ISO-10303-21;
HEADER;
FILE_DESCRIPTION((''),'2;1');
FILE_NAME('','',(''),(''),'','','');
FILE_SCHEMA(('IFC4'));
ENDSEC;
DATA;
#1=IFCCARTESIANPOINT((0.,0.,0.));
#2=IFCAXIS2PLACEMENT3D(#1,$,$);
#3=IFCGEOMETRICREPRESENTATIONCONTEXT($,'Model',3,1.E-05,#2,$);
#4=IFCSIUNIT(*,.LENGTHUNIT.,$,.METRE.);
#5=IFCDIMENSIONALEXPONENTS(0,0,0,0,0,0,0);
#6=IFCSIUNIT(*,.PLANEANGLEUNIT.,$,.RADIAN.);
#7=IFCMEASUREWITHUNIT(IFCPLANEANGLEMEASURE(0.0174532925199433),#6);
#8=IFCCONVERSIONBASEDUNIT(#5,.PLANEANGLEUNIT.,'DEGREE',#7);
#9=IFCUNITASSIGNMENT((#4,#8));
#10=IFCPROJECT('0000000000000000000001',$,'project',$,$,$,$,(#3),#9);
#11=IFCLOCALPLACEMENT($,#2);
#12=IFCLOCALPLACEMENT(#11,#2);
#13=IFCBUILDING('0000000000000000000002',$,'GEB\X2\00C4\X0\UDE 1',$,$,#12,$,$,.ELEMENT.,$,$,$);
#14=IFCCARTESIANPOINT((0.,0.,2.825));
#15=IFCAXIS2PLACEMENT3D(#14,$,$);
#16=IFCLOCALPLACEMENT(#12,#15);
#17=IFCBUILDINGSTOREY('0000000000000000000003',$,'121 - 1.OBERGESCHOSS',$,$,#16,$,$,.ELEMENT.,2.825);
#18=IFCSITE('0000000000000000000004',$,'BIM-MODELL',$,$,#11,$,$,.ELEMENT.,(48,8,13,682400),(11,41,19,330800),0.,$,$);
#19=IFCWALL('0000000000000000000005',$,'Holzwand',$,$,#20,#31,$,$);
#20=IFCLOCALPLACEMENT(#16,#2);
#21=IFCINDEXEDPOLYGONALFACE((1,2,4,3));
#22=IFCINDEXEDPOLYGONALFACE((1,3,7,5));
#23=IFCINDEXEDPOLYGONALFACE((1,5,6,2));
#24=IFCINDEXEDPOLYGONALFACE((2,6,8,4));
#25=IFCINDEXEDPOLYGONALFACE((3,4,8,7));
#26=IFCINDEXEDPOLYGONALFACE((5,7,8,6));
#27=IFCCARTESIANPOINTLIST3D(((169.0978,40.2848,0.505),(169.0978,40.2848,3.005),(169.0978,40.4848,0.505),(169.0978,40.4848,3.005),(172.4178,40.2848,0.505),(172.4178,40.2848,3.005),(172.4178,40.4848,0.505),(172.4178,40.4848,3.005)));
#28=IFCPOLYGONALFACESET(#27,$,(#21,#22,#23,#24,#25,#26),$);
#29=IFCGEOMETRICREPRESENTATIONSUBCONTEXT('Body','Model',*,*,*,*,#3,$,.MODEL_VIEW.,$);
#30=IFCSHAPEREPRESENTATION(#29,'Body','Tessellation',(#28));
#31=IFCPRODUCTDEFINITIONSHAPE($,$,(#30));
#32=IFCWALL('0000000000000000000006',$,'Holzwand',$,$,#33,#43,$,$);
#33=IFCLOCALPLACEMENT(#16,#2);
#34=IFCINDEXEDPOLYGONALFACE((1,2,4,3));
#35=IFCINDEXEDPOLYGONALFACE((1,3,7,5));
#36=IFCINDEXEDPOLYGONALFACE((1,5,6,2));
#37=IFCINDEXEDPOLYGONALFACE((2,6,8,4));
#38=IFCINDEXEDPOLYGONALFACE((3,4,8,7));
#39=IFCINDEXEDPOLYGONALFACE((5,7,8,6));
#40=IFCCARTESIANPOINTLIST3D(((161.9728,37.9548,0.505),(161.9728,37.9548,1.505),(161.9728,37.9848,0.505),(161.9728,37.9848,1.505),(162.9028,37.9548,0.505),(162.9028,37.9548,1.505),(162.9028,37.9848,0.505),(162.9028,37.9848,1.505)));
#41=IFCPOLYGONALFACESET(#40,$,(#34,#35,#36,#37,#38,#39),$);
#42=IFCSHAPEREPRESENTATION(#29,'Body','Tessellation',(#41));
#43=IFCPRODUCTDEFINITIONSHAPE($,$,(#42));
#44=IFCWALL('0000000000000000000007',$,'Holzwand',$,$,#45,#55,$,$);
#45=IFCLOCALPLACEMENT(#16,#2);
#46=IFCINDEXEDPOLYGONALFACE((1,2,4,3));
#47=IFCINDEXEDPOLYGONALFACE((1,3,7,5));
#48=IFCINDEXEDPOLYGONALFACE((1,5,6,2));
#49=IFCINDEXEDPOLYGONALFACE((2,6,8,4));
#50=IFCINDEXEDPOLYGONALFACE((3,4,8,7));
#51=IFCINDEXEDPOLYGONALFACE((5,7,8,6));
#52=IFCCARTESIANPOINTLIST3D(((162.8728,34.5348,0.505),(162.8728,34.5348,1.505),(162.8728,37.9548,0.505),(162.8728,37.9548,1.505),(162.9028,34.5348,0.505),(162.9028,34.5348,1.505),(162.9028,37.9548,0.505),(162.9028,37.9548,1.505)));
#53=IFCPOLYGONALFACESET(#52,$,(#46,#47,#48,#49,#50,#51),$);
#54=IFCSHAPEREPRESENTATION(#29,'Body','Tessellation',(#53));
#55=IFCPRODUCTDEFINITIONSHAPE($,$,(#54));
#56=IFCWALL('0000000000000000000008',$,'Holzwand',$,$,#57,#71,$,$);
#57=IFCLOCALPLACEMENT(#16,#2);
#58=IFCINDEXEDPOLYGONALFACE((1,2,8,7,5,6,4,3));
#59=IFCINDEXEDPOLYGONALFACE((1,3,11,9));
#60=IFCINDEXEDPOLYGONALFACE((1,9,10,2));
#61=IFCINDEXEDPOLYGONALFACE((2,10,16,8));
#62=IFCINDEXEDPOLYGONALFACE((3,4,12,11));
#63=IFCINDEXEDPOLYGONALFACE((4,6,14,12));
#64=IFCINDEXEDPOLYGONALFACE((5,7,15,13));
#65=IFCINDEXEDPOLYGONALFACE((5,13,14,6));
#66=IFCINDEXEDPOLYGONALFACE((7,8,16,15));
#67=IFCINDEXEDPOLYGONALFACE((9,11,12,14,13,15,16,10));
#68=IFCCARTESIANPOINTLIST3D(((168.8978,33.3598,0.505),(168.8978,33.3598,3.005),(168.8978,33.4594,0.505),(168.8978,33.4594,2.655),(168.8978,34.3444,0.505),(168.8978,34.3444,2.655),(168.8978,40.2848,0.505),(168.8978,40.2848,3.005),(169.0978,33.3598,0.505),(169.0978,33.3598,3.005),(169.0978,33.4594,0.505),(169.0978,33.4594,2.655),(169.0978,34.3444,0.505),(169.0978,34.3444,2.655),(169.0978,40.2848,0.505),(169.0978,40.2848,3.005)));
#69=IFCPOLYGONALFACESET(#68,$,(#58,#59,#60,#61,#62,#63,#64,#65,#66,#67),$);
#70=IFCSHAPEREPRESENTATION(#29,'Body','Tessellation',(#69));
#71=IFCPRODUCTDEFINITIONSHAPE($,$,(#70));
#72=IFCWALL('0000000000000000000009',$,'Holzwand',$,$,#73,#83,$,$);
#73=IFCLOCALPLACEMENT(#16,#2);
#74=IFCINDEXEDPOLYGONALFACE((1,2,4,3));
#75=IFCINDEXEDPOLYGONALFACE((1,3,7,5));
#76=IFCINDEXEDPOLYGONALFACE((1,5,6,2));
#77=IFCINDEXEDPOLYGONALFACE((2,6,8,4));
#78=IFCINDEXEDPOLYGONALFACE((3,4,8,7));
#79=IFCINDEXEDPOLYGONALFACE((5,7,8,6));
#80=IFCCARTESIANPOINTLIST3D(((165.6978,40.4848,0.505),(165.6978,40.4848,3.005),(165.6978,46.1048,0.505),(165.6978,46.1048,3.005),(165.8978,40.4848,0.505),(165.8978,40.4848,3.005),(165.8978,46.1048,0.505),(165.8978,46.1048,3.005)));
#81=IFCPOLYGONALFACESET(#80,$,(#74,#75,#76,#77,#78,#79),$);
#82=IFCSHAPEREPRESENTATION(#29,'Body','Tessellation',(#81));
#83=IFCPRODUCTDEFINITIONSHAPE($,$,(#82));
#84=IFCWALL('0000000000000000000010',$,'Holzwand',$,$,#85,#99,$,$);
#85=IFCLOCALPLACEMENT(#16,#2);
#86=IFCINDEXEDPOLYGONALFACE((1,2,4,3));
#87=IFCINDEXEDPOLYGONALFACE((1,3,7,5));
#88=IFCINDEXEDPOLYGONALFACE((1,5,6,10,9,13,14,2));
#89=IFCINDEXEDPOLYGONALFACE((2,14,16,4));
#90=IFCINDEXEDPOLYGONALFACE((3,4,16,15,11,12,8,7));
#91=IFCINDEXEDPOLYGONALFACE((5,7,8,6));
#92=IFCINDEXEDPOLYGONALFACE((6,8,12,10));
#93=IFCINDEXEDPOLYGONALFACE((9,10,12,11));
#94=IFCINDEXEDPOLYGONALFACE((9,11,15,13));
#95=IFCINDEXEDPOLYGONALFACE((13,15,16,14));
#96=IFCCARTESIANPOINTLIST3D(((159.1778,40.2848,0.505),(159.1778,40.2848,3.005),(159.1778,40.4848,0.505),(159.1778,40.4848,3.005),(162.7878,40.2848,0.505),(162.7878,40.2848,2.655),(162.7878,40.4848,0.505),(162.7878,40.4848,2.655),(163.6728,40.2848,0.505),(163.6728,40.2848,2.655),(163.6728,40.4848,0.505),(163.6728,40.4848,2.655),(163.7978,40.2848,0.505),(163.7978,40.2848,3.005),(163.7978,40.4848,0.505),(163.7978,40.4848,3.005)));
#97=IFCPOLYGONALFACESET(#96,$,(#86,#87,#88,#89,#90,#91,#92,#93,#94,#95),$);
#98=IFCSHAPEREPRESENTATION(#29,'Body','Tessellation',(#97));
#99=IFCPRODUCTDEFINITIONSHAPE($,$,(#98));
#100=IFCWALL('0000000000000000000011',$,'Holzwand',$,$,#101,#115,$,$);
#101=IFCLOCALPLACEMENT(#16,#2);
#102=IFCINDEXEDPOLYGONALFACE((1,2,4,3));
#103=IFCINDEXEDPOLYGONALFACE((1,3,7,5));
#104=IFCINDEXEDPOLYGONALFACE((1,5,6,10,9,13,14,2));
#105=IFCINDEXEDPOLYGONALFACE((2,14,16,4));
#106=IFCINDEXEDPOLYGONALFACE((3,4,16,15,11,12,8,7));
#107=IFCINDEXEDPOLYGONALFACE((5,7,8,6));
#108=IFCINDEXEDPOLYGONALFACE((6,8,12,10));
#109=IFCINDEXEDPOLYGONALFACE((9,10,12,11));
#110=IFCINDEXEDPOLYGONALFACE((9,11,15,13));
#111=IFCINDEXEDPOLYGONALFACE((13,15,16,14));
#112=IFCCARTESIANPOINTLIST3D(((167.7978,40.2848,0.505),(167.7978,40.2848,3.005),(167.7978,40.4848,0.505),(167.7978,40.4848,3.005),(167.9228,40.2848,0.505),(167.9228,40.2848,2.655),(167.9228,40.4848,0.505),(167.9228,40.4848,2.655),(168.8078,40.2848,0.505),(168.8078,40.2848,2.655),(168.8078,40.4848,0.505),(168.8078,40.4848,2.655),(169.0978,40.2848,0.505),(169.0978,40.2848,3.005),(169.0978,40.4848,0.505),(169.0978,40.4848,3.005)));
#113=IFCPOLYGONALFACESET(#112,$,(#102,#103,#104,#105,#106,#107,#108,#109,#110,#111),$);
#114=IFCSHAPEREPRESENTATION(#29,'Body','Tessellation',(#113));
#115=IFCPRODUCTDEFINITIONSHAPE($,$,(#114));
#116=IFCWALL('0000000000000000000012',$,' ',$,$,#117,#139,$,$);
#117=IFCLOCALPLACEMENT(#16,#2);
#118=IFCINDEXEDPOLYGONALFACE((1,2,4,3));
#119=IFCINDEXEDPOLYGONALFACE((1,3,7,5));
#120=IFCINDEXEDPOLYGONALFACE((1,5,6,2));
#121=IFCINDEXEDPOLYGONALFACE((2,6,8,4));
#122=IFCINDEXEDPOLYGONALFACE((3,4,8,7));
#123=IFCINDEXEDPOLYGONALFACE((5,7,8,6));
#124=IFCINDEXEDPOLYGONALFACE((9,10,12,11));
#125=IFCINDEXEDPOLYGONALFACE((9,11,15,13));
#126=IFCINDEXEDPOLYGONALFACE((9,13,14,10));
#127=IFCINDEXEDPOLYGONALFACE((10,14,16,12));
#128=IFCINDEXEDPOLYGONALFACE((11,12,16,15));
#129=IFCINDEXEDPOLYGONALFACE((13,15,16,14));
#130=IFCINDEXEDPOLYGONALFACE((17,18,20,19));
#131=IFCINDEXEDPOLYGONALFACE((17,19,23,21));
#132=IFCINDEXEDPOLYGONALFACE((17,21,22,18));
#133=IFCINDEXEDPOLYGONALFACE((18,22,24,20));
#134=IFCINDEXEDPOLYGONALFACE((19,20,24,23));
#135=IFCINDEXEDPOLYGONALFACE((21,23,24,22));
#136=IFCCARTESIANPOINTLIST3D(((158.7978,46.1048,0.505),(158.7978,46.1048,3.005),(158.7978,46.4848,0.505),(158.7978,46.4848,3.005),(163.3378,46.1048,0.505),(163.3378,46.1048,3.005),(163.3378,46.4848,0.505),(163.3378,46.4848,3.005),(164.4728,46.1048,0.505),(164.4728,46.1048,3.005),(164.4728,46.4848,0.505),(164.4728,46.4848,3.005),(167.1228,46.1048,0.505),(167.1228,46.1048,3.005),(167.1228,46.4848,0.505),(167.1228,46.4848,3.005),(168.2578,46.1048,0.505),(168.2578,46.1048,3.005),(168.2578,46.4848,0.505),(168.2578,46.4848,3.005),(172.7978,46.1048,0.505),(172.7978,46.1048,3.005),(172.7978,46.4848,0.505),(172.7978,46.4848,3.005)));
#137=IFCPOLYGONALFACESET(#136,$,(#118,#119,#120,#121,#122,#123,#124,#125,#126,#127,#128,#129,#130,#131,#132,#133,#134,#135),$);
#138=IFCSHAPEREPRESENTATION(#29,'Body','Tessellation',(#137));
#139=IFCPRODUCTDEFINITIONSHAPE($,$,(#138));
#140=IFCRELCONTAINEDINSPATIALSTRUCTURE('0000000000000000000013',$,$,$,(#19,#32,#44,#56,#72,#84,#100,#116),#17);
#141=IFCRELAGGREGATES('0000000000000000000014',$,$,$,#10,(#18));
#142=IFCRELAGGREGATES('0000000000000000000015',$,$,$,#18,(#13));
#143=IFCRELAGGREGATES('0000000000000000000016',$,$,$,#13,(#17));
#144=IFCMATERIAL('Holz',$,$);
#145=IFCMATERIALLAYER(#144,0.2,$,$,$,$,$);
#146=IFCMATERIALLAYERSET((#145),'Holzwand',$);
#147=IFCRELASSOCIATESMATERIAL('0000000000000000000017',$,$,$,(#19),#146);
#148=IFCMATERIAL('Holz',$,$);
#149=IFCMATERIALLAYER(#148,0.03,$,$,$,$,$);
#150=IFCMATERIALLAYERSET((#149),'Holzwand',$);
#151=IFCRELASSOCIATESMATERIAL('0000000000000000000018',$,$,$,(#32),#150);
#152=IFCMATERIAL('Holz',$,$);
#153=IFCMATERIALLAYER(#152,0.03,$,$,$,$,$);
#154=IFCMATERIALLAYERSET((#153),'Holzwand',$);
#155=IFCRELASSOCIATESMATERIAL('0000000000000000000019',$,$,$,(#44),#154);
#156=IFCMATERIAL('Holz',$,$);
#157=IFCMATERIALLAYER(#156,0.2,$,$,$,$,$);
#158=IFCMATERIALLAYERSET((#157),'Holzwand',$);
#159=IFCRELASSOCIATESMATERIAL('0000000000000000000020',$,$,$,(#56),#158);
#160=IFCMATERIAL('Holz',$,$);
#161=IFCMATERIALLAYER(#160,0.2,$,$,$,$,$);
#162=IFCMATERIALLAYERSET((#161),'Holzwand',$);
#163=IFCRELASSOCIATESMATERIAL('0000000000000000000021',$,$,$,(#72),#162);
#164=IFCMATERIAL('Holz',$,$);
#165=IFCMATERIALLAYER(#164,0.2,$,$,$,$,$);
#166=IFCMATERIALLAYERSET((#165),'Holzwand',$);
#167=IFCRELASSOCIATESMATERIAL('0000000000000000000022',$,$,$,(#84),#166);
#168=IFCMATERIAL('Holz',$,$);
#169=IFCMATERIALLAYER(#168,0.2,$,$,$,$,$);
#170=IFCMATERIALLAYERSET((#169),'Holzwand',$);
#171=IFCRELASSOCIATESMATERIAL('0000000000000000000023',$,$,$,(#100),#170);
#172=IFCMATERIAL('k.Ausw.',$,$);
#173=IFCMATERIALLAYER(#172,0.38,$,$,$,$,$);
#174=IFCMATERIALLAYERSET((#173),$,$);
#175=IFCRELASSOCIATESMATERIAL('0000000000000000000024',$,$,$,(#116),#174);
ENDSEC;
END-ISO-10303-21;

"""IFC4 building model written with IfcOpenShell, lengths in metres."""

from ifc_helpers import new_model, entity, si_unit, converted_unit, frame, frame_2d, origin, origin_with_axes, place, context, subcontext, project, spatial, polyline, rectangle, outline, extrude, material, layer, layer_set, layer_usage, element, save


model = new_model("IFC4")

# Units and contexts
model_context = context("Model", 3, precision=1e-05, world=origin())
body_context = subcontext(model_context, "Body", "Model", "MODEL_VIEW")
ifc_project = project(units=[si_unit("LENGTHUNIT", "METRE"), converted_unit("PLANEANGLEUNIT", "DEGREE", entity("IfcPlaneAngleMeasure", 0.0174532925199433), si_unit("PLANEANGLEUNIT", "RADIAN"), dimensions=[0, 0, 0, 0, 0, 0, 0])], contexts=[model_context])

# Site, building, storey
site_placement = place(None, origin())
site = spatial("IfcSite", under=ifc_project, at=site_placement, Name="BIM-MODELL", CompositionType="ELEMENT", RefLatitude=(48, 8, 13, 682400), RefLongitude=(11, 41, 19, 330800), RefElevation=0.0)
building_placement = place(site_placement, origin())
building = spatial("IfcBuilding", under=site, at=building_placement, Name="GEBÄUDE 1", CompositionType="ELEMENT")
storey_placement = place(building_placement, frame((0.0, 0.0, 2.825)))
storey = spatial("IfcBuildingStorey", under=building, at=storey_placement, Name="121 - 1.OBERGESCHOSS", CompositionType="ELEMENT", Elevation=2.825)

# Walls
ifc_material_1 = material(Name="Holz")
ifc_layer_1 = layer(ifc_material_1, 0.2)
ifc_layer_set_1 = layer_set([ifc_layer_1], Name="Holzwand")
ifc_layer_usage_1 = layer_usage(ifc_layer_set_1, "AXIS2", "POSITIVE", -0.1)
wall_1_placement = place(storey_placement, frame((172.4178, 40.4848, 0.505), z_axis=(0.0, 0.0, 1.0), x_axis=(-1.0, 0.0, 0.0)))
element("IfcWall", 1, at=wall_1_placement, inside=storey, material=ifc_layer_usage_1, Name="Holzwand", context=body_context, shape_type="SweptSolid", body=[
    extrude(rectangle(XDim=3.32, YDim=0.2, at=frame_2d((1.66, 0.1), x_axis=(1.0, 0.0))), origin_with_axes(), (0.0, 0.0, 1.0), 2.5),
])
ifc_material_2 = material(Name="Holz")
ifc_layer_2 = layer(ifc_material_2, 0.03)
ifc_layer_set_2 = layer_set([ifc_layer_2], Name="Holzwand")
ifc_layer_usage_2 = layer_usage(ifc_layer_set_2, "AXIS2", "POSITIVE", 0.0)
wall_2_placement = place(storey_placement, frame((161.9728, 37.9548, 0.505), z_axis=(0.0, 0.0, 1.0), x_axis=(1.0, 0.0, 0.0)))
element("IfcWall", 2, at=wall_2_placement, inside=storey, material=ifc_layer_usage_2, Name="Holzwand", context=body_context, shape_type="SweptSolid", body=[
    extrude(rectangle(XDim=0.93, YDim=0.03, at=frame_2d((0.465, 0.015), x_axis=(1.0, 0.0))), origin_with_axes(), (0.0, 0.0, 1.0), 1.0),
])
ifc_material_3 = material(Name="Holz")
ifc_layer_3 = layer(ifc_material_3, 0.03)
ifc_layer_set_3 = layer_set([ifc_layer_3], Name="Holzwand")
ifc_layer_usage_3 = layer_usage(ifc_layer_set_3, "AXIS2", "POSITIVE", 0.0)
wall_3_placement = place(storey_placement, frame((162.8728, 37.9548, 0.505), z_axis=(0.0, 0.0, 1.0), x_axis=(0.0, -1.0, 0.0)))
element("IfcWall", 3, at=wall_3_placement, inside=storey, material=ifc_layer_usage_3, Name="Holzwand", context=body_context, shape_type="SweptSolid", body=[
    extrude(rectangle(XDim=3.42, YDim=0.03, at=frame_2d((1.71, 0.015), x_axis=(1.0, 0.0))), origin_with_axes(), (0.0, 0.0, 1.0), 1.0),
])

# Wall, opening
ifc_material_4 = material(Name="Holz")
ifc_layer_4 = layer(ifc_material_4, 0.2)
ifc_layer_set_4 = layer_set([ifc_layer_4], Name="Holzwand")
ifc_layer_usage_4 = layer_usage(ifc_layer_set_4, "AXIS2", "POSITIVE", 0.0)
wall_4_placement = place(storey_placement, frame((168.8978, 40.2848, 0.505), z_axis=(0.0, 0.0, 1.0), x_axis=(0.0, -1.0, 0.0)))
wall_4 = element("IfcWall", 4, at=wall_4_placement, inside=storey, material=ifc_layer_usage_4, Name="Holzwand", context=body_context, shape_type="SweptSolid", body=[
    extrude(rectangle(XDim=6.925, YDim=0.2, at=frame_2d((3.4625, 0.1), x_axis=(1.0, 0.0))), origin_with_axes(), (0.0, 0.0, 1.0), 2.5),
])
opening_1_placement = place(wall_4_placement, frame((5.9404, 0.0, -0.15), z_axis=(0.0, 1.0, 0.0), x_axis=(0.0, 0.0, 1.0)))
element("IfcOpeningElement", 5, at=opening_1_placement, cuts=wall_4, ObjectType="Opening", context=body_context, shape_type="SweptSolid", body=[
    extrude(outline(polyline([(0.0, 0.885), (2.3, 0.885), (2.3, 0.0), (0.0, 0.0), (0.0, 0.885)])), origin_with_axes(), (0.0, 0.0, 1.0), 0.2),
])

# Wall
ifc_material_5 = material(Name="Holz")
ifc_layer_5 = layer(ifc_material_5, 0.2)
ifc_layer_set_5 = layer_set([ifc_layer_5], Name="Holzwand")
ifc_layer_usage_5 = layer_usage(ifc_layer_set_5, "AXIS2", "POSITIVE", 0.0)
wall_5_placement = place(storey_placement, frame((165.6978, 46.1048, 0.505), z_axis=(0.0, 0.0, 1.0), x_axis=(0.0, -1.0, 0.0)))
element("IfcWall", 6, at=wall_5_placement, inside=storey, material=ifc_layer_usage_5, Name="Holzwand", context=body_context, shape_type="SweptSolid", body=[
    extrude(rectangle(XDim=5.62, YDim=0.2, at=frame_2d((2.81, 0.1), x_axis=(1.0, 0.0))), origin_with_axes(), (0.0, 0.0, 1.0), 2.5),
])

# Walls, openings
ifc_material_6 = material(Name="Holz")
ifc_layer_6 = layer(ifc_material_6, 0.2)
ifc_layer_set_6 = layer_set([ifc_layer_6], Name="Holzwand")
ifc_layer_usage_6 = layer_usage(ifc_layer_set_6, "AXIS2", "POSITIVE", 0.0)
wall_6_placement = place(storey_placement, frame((163.7978, 40.4848, 0.505), z_axis=(0.0, 0.0, 1.0), x_axis=(-1.0, 0.0, 0.0)))
wall_6 = element("IfcWall", 7, at=wall_6_placement, inside=storey, material=ifc_layer_usage_6, Name="Holzwand", context=body_context, shape_type="SweptSolid", body=[
    extrude(rectangle(XDim=4.62, YDim=0.2, at=frame_2d((2.31, 0.1), x_axis=(1.0, 0.0))), origin_with_axes(), (0.0, 0.0, 1.0), 2.5),
])
opening_2_placement = place(wall_6_placement, frame((1.01, 0.2, -0.15), z_axis=(0.0, -1.0, 0.0), x_axis=(0.0, 0.0, 1.0)))
element("IfcOpeningElement", 8, at=opening_2_placement, cuts=wall_6, ObjectType="Opening", context=body_context, shape_type="SweptSolid", body=[
    extrude(outline(polyline([(0.0, 0.885), (2.3, 0.885), (2.3, 0.0), (0.0, 0.0), (0.0, 0.885)])), origin_with_axes(), (0.0, 0.0, 1.0), 0.2),
])
ifc_material_7 = material(Name="Holz")
ifc_layer_7 = layer(ifc_material_7, 0.2)
ifc_layer_set_7 = layer_set([ifc_layer_7], Name="Holzwand")
ifc_layer_usage_7 = layer_usage(ifc_layer_set_7, "AXIS2", "POSITIVE", 0.0)
wall_7_placement = place(storey_placement, frame((169.0978, 40.4848, 0.505), z_axis=(0.0, 0.0, 1.0), x_axis=(-1.0, 0.0, 0.0)))
wall_7 = element("IfcWall", 9, at=wall_7_placement, inside=storey, material=ifc_layer_usage_7, Name="Holzwand", context=body_context, shape_type="SweptSolid", body=[
    extrude(rectangle(XDim=1.3, YDim=0.2, at=frame_2d((0.65, 0.1), x_axis=(1.0, 0.0))), origin_with_axes(), (0.0, 0.0, 1.0), 2.5),
])
opening_3_placement = place(wall_7_placement, frame((1.175, 0.2, -0.15), z_axis=(0.0, -1.0, 0.0), x_axis=(0.0, 0.0, 1.0)))
element("IfcOpeningElement", 10, at=opening_3_placement, cuts=wall_7, ObjectType="Opening", context=body_context, shape_type="SweptSolid", body=[
    extrude(outline(polyline([(0.0, 0.885), (2.3, 0.885), (2.3, 0.0), (0.0, 0.0), (0.0, 0.885)])), origin_with_axes(), (0.0, 0.0, 1.0), 0.2),
])

# Wall, openings
ifc_material_8 = material(Name="k.Ausw.")
ifc_layer_8 = layer(ifc_material_8, 0.38)
ifc_layer_set_8 = layer_set([ifc_layer_8])
ifc_layer_usage_8 = layer_usage(ifc_layer_set_8, "AXIS2", "POSITIVE", 0.0)
wall_8_placement = place(storey_placement, frame((172.7978, 46.4848, 0.505), z_axis=(0.0, 0.0, 1.0), x_axis=(-1.0, 0.0, 0.0)))
wall_8 = element("IfcWall", 11, at=wall_8_placement, inside=storey, material=ifc_layer_usage_8, Name=" ", context=body_context, shape_type="SweptSolid", body=[
    extrude(rectangle(XDim=14.0, YDim=0.38, at=frame_2d((7.0, 0.19), x_axis=(1.0, 0.0))), origin_with_axes(), (0.0, 0.0, 1.0), 2.5),
])
opening_4_placement = place(wall_8_placement, frame((5.675, 0.38, 0.0), z_axis=(0.0, -1.0, 0.0), x_axis=(0.0, 0.0, 1.0)))
element("IfcOpeningElement", 12, at=opening_4_placement, cuts=wall_8, ObjectType="Opening", context=body_context, shape_type="SweptSolid", body=[
    extrude(outline(polyline([(0.0, 1.135), (2.5, 1.135), (2.5, 0.0), (0.0, 0.0), (0.0, 1.135)])), origin_with_axes(), (0.0, 0.0, 1.0), 0.38),
])
opening_5_placement = place(wall_8_placement, frame((9.46, 0.38, 0.0), z_axis=(0.0, -1.0, 0.0), x_axis=(0.0, 0.0, 1.0)))
element("IfcOpeningElement", 13, at=opening_5_placement, cuts=wall_8, ObjectType="Opening", context=body_context, shape_type="SweptSolid", body=[
    extrude(outline(polyline([(0.0, 1.135), (2.5, 1.135), (2.5, 0.0), (0.0, 0.0), (0.0, 1.135)])), origin_with_axes(), (0.0, 0.0, 1.0), 0.38),
])

save(model, "model.ifc")
